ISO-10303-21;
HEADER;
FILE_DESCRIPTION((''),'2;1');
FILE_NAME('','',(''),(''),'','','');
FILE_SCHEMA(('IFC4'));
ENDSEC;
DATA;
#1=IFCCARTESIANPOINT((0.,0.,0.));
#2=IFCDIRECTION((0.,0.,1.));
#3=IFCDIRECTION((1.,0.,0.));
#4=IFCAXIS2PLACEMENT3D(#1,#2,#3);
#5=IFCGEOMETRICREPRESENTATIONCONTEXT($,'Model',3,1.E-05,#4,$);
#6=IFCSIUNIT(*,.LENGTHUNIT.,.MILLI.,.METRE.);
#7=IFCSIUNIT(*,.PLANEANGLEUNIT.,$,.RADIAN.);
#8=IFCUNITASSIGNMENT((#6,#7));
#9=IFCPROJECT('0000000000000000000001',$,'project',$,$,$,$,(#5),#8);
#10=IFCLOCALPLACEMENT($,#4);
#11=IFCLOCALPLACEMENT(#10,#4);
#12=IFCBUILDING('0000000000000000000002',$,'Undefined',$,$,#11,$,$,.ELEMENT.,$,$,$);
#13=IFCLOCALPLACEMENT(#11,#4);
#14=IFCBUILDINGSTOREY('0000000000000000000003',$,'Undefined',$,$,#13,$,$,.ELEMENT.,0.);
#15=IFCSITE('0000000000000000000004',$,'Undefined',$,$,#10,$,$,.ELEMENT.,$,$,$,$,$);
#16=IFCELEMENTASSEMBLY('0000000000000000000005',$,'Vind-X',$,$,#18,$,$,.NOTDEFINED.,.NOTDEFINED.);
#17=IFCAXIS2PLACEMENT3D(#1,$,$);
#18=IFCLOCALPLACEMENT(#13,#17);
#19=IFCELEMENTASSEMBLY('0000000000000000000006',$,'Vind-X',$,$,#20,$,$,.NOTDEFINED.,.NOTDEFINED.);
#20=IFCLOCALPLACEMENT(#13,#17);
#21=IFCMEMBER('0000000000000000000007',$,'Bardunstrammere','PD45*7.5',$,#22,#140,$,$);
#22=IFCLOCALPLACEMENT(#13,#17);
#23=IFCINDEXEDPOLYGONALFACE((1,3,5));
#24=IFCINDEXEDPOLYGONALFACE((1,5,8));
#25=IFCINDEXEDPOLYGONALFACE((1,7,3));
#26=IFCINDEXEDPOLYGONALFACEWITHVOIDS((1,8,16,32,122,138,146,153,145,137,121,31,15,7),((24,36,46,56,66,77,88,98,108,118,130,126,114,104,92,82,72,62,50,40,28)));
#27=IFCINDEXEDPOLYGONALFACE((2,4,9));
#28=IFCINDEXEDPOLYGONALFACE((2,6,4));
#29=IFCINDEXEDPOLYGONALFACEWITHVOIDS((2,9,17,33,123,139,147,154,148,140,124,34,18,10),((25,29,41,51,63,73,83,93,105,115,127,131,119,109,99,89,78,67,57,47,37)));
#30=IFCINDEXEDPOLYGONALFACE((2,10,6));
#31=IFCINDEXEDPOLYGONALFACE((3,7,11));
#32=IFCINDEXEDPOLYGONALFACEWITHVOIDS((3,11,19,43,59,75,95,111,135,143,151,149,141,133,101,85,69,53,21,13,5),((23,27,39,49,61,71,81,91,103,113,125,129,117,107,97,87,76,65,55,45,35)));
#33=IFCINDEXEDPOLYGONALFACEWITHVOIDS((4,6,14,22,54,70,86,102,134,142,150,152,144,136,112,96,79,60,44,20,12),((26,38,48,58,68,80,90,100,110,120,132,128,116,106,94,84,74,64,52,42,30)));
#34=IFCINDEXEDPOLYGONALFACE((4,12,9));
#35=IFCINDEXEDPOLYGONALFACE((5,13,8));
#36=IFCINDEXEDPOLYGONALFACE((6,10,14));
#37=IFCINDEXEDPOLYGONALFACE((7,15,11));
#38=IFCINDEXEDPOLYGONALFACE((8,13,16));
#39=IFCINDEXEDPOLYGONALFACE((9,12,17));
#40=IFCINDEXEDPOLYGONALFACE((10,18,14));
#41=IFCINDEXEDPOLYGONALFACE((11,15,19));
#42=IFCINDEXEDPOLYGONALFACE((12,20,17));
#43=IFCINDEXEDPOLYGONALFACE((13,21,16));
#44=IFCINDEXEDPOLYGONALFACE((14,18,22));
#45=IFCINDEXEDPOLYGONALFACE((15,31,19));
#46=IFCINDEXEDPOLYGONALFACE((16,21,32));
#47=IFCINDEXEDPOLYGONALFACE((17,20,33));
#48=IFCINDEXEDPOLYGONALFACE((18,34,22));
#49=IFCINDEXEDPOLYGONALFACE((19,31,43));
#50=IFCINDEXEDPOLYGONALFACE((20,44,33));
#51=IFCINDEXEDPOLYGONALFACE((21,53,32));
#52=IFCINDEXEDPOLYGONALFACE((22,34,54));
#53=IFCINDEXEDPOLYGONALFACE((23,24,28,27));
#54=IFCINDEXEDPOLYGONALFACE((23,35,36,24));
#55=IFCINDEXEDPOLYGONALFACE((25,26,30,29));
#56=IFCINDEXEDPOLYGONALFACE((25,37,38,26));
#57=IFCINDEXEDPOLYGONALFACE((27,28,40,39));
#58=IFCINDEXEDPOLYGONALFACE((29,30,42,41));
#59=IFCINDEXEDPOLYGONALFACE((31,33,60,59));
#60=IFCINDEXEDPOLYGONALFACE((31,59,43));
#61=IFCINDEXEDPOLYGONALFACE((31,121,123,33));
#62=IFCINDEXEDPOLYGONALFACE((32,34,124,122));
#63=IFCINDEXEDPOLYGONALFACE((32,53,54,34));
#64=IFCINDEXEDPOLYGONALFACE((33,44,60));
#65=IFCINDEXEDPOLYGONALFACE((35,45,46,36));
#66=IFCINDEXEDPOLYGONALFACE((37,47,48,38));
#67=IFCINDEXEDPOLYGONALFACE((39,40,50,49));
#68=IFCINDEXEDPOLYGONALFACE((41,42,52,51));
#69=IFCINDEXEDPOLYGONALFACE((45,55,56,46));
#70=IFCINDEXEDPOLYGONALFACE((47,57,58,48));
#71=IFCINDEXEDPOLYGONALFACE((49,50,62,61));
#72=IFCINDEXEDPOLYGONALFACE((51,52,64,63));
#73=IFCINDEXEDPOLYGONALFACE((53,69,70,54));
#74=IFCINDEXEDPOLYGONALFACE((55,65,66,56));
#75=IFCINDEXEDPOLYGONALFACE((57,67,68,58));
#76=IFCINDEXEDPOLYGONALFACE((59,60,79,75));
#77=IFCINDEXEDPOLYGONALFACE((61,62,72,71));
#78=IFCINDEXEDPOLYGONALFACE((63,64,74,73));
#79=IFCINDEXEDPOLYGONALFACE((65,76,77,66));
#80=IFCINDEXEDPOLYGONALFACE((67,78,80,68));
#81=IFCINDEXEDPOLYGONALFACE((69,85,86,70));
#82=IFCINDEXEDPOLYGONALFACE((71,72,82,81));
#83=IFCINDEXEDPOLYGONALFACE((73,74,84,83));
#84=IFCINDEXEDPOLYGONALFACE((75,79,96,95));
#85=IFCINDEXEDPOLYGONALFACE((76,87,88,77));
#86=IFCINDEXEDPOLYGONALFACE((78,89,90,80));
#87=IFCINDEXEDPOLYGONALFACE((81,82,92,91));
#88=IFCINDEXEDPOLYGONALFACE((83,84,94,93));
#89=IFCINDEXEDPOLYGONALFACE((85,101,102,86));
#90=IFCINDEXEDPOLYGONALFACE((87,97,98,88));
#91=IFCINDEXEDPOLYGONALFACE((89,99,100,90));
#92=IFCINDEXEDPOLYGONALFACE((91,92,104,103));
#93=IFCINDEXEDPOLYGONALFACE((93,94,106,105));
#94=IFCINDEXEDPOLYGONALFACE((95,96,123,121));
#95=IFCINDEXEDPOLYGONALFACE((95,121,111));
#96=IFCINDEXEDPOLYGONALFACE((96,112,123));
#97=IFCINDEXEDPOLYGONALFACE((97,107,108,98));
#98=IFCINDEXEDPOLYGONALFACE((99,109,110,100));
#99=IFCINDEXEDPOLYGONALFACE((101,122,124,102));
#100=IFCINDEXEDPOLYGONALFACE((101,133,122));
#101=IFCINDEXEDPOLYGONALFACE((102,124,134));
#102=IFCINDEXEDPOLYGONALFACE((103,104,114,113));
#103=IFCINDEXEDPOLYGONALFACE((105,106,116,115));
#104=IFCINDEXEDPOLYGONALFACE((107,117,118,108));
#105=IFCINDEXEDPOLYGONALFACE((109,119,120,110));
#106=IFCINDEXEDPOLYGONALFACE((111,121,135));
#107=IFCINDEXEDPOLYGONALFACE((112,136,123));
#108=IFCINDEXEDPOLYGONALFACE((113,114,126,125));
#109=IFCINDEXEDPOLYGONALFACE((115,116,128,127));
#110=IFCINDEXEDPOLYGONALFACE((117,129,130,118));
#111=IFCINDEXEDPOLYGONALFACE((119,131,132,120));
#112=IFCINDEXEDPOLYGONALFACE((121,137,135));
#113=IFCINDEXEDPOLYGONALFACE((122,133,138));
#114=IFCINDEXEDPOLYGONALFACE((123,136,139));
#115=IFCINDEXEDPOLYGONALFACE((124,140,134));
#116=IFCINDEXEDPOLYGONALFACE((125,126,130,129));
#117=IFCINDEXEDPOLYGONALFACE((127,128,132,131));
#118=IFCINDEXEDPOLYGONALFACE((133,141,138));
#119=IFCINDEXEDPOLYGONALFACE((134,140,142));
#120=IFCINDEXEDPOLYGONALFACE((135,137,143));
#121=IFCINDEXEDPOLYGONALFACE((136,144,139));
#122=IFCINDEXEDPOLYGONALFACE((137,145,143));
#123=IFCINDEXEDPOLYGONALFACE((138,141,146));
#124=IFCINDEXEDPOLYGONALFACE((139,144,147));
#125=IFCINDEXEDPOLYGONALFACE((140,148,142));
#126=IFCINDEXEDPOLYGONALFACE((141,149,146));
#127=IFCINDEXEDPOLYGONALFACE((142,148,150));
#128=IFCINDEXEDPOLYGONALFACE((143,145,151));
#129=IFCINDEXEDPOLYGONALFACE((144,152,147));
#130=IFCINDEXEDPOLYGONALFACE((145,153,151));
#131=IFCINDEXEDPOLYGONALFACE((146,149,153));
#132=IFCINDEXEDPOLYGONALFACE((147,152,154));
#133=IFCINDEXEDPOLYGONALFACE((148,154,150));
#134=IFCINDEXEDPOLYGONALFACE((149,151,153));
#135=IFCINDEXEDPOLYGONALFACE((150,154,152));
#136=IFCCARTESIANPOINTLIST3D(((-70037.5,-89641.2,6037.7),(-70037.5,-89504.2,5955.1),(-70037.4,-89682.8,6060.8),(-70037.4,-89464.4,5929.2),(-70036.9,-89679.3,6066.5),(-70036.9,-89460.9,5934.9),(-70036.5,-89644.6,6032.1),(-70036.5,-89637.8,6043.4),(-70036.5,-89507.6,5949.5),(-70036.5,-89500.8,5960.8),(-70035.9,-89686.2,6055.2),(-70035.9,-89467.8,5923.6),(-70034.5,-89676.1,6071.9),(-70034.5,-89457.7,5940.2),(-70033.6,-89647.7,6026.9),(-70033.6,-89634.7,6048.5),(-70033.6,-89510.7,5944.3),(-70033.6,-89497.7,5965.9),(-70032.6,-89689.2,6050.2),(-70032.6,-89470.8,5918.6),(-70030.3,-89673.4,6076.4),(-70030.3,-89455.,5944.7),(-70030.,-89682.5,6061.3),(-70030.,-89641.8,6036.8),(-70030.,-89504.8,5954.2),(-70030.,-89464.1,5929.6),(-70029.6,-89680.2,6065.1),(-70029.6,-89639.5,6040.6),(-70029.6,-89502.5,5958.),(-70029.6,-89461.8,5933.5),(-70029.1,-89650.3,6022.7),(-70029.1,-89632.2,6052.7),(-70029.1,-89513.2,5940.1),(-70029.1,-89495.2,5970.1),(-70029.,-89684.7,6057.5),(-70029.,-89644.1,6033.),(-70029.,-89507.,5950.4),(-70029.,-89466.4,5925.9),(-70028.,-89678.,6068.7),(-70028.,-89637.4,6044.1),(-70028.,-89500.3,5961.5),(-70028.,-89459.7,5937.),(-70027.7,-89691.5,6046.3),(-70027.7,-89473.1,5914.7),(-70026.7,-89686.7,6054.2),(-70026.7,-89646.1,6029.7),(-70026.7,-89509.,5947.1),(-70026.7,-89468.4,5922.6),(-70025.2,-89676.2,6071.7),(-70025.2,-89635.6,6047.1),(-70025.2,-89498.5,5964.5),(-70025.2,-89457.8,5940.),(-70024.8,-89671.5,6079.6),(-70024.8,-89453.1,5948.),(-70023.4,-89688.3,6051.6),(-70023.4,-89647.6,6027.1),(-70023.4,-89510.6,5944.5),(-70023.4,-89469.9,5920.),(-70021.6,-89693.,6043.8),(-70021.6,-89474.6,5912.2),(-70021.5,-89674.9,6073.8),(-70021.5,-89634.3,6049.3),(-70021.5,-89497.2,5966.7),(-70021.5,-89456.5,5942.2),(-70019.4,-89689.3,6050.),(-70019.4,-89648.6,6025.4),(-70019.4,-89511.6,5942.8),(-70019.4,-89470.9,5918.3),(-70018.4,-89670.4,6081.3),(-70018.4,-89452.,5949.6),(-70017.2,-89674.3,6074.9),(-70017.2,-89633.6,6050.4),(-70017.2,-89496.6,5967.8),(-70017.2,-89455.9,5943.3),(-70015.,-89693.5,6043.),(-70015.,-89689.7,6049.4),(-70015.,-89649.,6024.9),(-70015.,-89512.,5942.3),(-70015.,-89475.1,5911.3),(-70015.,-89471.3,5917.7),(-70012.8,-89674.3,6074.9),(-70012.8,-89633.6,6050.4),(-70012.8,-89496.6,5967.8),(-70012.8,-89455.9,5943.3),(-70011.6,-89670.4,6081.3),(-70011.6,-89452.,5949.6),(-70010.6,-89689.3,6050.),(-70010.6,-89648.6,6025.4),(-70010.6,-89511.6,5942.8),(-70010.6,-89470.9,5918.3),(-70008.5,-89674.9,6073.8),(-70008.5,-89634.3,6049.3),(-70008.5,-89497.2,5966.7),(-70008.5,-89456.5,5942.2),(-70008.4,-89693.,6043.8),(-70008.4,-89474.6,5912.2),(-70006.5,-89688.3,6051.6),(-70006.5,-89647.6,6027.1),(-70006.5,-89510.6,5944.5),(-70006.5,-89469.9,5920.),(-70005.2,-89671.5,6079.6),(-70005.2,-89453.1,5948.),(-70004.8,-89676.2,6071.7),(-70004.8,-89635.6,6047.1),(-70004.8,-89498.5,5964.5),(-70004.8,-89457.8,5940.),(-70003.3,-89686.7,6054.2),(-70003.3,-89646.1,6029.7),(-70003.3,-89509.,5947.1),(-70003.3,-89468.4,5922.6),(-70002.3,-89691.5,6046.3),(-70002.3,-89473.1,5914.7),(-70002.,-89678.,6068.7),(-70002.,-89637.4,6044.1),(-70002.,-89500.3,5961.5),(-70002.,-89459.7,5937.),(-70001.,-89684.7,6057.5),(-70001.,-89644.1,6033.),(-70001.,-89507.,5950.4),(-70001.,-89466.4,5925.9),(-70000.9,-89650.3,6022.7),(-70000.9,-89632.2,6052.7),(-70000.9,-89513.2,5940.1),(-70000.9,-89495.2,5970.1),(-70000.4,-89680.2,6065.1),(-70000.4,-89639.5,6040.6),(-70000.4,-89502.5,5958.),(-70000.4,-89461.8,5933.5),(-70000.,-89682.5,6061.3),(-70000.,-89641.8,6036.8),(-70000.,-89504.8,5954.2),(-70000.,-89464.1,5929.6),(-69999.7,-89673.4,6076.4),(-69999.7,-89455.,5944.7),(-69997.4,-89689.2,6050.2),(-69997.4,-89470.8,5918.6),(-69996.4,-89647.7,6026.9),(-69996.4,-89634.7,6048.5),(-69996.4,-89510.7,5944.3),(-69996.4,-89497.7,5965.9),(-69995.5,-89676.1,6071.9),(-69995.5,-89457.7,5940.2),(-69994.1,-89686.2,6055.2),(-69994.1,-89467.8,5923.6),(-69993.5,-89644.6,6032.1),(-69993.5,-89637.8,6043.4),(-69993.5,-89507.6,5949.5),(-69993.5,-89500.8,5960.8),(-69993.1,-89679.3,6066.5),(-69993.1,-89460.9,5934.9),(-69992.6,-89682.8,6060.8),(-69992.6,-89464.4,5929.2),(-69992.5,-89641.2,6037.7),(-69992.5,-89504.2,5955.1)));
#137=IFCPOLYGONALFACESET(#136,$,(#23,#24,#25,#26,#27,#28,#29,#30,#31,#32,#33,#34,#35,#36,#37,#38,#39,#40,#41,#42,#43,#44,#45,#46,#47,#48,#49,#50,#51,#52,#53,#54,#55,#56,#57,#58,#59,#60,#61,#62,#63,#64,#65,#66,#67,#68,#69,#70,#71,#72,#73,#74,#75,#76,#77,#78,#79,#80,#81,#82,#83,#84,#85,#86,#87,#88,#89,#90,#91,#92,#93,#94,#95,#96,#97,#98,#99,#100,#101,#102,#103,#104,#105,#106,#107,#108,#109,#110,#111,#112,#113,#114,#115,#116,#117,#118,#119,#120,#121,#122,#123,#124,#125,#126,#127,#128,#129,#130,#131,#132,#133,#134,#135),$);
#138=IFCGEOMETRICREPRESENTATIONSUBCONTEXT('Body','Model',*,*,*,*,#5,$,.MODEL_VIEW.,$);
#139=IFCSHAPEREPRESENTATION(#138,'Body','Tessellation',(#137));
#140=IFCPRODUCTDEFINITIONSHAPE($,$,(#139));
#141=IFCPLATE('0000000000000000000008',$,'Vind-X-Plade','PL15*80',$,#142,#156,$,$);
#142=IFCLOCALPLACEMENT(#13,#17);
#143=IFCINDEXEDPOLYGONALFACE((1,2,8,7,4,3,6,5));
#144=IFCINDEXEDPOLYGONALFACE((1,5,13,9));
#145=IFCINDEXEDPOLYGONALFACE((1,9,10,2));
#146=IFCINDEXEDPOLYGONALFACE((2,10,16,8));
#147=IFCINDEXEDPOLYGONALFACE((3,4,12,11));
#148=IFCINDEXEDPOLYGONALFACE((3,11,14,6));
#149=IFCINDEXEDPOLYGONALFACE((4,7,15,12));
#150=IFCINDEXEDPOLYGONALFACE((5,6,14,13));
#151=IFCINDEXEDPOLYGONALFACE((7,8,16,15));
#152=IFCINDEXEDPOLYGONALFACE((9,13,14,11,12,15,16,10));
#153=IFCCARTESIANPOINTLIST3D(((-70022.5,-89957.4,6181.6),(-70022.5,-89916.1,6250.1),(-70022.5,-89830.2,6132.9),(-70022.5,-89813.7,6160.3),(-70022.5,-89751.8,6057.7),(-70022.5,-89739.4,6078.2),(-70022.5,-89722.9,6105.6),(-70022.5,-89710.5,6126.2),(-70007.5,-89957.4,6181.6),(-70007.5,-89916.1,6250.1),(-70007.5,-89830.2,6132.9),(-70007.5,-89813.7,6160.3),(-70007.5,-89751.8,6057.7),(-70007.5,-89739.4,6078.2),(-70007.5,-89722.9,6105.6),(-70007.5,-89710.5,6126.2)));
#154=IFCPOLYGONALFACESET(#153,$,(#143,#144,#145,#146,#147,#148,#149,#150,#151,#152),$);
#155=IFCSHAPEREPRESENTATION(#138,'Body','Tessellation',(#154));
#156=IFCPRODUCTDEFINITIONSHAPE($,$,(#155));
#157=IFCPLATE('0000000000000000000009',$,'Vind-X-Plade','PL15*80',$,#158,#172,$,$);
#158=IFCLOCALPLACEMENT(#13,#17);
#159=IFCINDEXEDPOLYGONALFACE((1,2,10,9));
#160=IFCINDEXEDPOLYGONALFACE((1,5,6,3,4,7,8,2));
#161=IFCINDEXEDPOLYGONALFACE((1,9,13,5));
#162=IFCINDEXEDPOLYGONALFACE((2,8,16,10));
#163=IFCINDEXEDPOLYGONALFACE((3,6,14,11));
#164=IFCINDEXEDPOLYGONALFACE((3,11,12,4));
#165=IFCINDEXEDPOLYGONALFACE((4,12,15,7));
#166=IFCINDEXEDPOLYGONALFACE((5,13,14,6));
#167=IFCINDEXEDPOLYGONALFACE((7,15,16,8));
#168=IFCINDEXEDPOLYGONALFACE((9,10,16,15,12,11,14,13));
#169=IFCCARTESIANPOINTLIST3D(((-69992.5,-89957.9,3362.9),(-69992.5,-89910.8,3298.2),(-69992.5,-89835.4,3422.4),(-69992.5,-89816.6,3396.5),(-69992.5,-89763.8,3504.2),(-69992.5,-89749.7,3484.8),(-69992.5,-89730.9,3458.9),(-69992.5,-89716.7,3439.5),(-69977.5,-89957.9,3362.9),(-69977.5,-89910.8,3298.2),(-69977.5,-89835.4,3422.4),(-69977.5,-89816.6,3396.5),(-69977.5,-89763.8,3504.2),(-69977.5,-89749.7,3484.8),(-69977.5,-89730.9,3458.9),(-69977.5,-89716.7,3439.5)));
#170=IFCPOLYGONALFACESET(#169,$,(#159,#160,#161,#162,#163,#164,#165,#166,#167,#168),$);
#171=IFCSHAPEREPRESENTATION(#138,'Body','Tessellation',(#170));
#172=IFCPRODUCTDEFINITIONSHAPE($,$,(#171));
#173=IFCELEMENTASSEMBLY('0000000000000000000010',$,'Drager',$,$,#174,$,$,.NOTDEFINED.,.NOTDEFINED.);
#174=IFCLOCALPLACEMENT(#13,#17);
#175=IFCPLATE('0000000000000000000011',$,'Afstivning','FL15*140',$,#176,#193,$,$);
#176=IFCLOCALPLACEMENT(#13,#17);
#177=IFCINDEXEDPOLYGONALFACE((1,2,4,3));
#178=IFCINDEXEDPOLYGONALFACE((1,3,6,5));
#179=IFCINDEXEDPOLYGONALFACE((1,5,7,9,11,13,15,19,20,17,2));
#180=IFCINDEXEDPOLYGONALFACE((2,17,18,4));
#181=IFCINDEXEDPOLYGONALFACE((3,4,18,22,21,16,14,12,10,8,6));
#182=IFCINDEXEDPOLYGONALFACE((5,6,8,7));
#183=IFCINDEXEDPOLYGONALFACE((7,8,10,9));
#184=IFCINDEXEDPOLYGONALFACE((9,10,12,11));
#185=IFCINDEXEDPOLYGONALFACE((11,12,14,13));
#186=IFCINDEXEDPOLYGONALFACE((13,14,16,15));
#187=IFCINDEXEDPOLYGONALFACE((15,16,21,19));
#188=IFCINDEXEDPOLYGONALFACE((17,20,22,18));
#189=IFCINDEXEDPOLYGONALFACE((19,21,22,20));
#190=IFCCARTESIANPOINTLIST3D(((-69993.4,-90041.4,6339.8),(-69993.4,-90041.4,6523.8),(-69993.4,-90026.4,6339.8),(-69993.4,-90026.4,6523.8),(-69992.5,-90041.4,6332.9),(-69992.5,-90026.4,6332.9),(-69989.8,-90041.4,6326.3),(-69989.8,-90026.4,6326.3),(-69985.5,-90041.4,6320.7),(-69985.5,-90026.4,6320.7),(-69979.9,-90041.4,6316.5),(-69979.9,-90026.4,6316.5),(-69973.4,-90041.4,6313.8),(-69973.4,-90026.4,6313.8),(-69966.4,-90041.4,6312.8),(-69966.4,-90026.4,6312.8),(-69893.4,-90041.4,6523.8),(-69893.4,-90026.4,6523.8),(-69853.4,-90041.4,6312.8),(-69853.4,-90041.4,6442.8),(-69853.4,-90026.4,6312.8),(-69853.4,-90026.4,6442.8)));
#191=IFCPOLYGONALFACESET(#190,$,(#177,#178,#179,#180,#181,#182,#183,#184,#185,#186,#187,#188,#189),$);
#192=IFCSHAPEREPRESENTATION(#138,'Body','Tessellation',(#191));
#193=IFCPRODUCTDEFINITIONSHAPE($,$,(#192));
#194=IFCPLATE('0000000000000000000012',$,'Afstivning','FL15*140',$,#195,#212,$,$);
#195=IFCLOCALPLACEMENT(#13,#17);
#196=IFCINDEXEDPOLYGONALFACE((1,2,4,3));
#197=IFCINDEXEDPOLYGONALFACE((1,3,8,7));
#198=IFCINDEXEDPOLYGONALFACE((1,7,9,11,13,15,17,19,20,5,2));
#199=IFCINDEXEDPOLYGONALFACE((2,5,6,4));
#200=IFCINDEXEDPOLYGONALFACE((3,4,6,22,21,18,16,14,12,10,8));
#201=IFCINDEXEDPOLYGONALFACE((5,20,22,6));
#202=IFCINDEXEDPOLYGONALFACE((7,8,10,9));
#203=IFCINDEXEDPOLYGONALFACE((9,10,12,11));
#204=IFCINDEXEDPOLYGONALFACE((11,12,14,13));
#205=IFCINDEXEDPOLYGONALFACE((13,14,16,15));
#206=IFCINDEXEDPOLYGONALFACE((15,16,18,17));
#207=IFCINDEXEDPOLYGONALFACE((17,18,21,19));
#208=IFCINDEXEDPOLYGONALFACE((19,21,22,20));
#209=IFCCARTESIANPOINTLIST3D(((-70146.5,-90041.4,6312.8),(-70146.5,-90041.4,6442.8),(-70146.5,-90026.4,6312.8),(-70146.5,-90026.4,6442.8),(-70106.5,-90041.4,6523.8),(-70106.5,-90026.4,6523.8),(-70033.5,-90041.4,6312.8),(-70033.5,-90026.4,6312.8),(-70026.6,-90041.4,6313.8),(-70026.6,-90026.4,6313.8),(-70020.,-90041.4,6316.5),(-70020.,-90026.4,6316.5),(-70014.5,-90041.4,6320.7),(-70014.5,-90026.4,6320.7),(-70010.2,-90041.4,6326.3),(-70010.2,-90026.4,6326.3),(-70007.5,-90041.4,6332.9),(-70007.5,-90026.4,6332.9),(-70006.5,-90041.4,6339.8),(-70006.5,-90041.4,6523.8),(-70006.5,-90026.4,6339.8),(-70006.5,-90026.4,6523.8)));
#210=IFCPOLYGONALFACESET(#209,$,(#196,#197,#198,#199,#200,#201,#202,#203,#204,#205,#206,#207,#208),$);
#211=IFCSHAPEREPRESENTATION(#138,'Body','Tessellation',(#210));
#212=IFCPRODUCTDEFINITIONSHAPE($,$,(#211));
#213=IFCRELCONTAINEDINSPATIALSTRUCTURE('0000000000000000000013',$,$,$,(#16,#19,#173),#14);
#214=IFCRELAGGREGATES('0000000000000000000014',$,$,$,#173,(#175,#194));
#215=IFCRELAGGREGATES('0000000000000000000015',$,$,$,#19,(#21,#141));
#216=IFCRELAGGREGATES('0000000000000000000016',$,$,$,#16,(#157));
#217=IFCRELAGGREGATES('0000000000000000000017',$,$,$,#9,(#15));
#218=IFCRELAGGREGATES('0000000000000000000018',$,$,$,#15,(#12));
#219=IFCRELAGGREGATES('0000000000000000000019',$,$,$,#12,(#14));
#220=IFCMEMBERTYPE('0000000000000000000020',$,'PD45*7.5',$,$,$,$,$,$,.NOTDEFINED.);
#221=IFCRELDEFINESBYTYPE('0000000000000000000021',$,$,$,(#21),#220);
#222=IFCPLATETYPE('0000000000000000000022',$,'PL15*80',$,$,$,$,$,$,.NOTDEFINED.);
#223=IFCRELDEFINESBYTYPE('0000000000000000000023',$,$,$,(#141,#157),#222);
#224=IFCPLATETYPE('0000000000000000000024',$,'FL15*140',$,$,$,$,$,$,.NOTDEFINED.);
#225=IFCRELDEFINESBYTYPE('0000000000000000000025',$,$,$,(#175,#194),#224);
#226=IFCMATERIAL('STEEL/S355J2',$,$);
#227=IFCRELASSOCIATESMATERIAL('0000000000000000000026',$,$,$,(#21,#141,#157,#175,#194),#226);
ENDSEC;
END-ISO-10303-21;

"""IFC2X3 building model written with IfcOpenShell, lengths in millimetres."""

from ifc_helpers import new_model, si_unit, frame, frame_2d, origin_with_axes, origin_2d_with_axis, place, context, subcontext, project, spatial, polyline, circle_curve, parameter, trimmed, segment, composite_curve, rectangle, hollow_circle, outline, extrude, boolean, material, type_object, element, aggregate, save


model = new_model("IFC2X3")

# Units and contexts
model_context = context("Model", 3, precision=1e-05, world=origin_with_axes())
body_context = subcontext(model_context, "Body", "Model", "MODEL_VIEW")
ifc_project = project(units=[si_unit("LENGTHUNIT", "METRE", prefix="MILLI"), si_unit("PLANEANGLEUNIT", "RADIAN")], contexts=[model_context])

# Site, building, storey
site_placement = place(None, origin_with_axes())
site = spatial("IfcSite", under=ifc_project, at=site_placement, Name="Undefined", CompositionType="ELEMENT")
building_placement = place(site_placement, origin_with_axes())
building = spatial("IfcBuilding", under=site, at=building_placement, Name="Undefined", CompositionType="ELEMENT")
storey_placement = place(building_placement, origin_with_axes())
storey = spatial("IfcBuildingStorey", under=building, at=storey_placement, Name="Undefined", CompositionType="ELEMENT", Elevation=0.0)

# Element assembly
assembly_1_placement = place(storey_placement, origin_with_axes())
assembly_1 = element("IfcElementAssembly", 1, at=assembly_1_placement, inside=storey, Name="Vind-X", AssemblyPlace="NOTDEFINED", PredefinedType="NOTDEFINED")
ifc_material_1 = material(Name="STEEL/S355J2")

# Element assembly, member, plate
assembly_2_placement = place(storey_placement, origin_with_axes())
assembly_2 = element("IfcElementAssembly", 2, at=assembly_2_placement, inside=storey, Name="Vind-X", AssemblyPlace="NOTDEFINED", PredefinedType="NOTDEFINED")
member_type_1 = type_object("IfcMemberType", Name="PD45*7.5", PredefinedType="NOTDEFINED")
member_1_placement = place(assembly_2_placement, frame((-70015.0, -89681.9, 6062.2), z_axis=(1.0, 0.0, 0.0), x_axis=(0.0, 0.85644, -0.516247)))
member_1 = element("IfcMember", 3, at=member_1_placement, type_object=member_type_1, material=ifc_material_1, Name="Bardunstrammere", Description="PD45*7.5", context=body_context, shape_type="CSG", body=[
    boolean("DIFFERENCE", extrude(hollow_circle(Radius=22.5, WallThickness=7.5, at=origin_2d_with_axis()), frame((255.0, 0.0, 0.0), z_axis=(-1.0, 0.0, 0.0), x_axis=(0.0, -1.0, 0.0)), (0.0, 0.0, 1.0), 255.0), extrude(rectangle(XDim=35.0, YDim=90.0, at=origin_2d_with_axis()), frame((207.5, 0.0, 0.0), z_axis=(-1.0, 0.0, 0.0), x_axis=(0.0, -1.0, 0.0)), (0.0, 0.0, 1.0), 160.0)),
])
plate_type_1 = type_object("IfcPlateType", Name="PL15*80", PredefinedType="NOTDEFINED")
plate_1_placement = place(assembly_2_placement, frame((-70015.0, -89957.4, 6181.6), z_axis=(-1.0, 0.0, 0.0), x_axis=(0.0, 0.516238, 0.856445)))
plate_1 = element("IfcPlate", 4, at=plate_1_placement, type_object=plate_type_1, material=ifc_material_1, Name="Vind-X-Plade", Description="PL15*80", context=body_context, shape_type="CSG", body=[
    boolean("DIFFERENCE", extrude(outline(polyline([(0.0, 0.0), (80.0, 0.0), (80.0, 240.0), (0.0, 240.0), (0.0, 0.0)])), frame((0.0, 0.0, -7.5), z_axis=(0.0, 0.0, 1.0), x_axis=(1.0, 0.0, 0.0)), (0.0, 0.0, 1.0), 15.0), extrude(outline(polyline([(0.0, 0.0), (106.0, 0.0), (106.0, 32.0), (0.0, 32.0), (0.0, 0.0)])), frame((56.0, 240.0, 8.5), z_axis=(0.0, 0.0, -1.0), x_axis=(0.000011, -1.0, 0.0)), (0.0, 0.0, 1.0), 17.0)),
])

# Plate
plate_2_placement = place(assembly_1_placement, frame((-69985.0, -89910.8, 3298.2), z_axis=(-1.0, 0.0, 0.0), x_axis=(0.0, -0.588607, 0.80842)))
plate_2 = element("IfcPlate", 5, at=plate_2_placement, type_object=plate_type_1, material=ifc_material_1, Name="Vind-X-Plade", Description="PL15*80", context=body_context, shape_type="CSG", body=[
    boolean("DIFFERENCE", extrude(outline(polyline([(0.0, 0.0), (80.0, 0.0), (80.0, 240.0), (0.0, 240.0), (0.0, 0.0)])), frame((0.0, 0.0, -7.5), z_axis=(0.0, 0.0, 1.0), x_axis=(1.0, 0.0, 0.0)), (0.0, 0.0, 1.0), 15.0), extrude(outline(polyline([(0.0, 0.0), (106.0, 0.0), (106.0, 32.0), (0.0, 32.0), (0.0, 0.0)])), frame((56.0, 240.0, 8.5), z_axis=(0.0, 0.0, -1.0), x_axis=(-0.00001, -1.0, 0.0)), (0.0, 0.0, 1.0), 17.0)),
])

# Element assembly, plates
assembly_3_placement = place(storey_placement, origin_with_axes())
assembly_3 = element("IfcElementAssembly", 6, at=assembly_3_placement, inside=storey, Name="Drager", AssemblyPlace="NOTDEFINED", PredefinedType="NOTDEFINED")
plate_type_2 = type_object("IfcPlateType", Name="FL15*140", PredefinedType="NOTDEFINED")
plate_3_placement = place(assembly_3_placement, frame((-69993.4, -90033.9, 6312.8), z_axis=(0.0, -1.0, 0.0), x_axis=(1.0, 0.0, 0.0)))
plate_3 = element("IfcPlate", 7, at=plate_3_placement, type_object=plate_type_2, material=ifc_material_1, Name="Afstivning", Description="FL15*140", context=body_context, shape_type="SweptSolid", body=[
    extrude(outline(composite_curve([segment(trimmed(circle_curve(frame_2d((27.0, 27.0), x_axis=(-1.0, 0.0)), 27.0), [parameter(0.0)], [parameter(1.570796)], True, "PARAMETER"), True, "CONTINUOUS"), segment(polyline([(27.0, 0.0), (140.0, 0.0), (140.0, 130.0), (100.0, 211.0), (0.0, 211.0), (0.0, 27.0)]), True, "CONTINUOUS")], self_intersect=True)), frame((0.0, 0.0, -7.5), z_axis=(0.0, 0.0, 1.0), x_axis=(1.0, 0.0, 0.0)), (0.0, 0.0, 1.0), 15.0),
])
plate_4_placement = place(assembly_3_placement, frame((-70146.5, -90033.9, 6312.8), z_axis=(0.0, -1.0, 0.0), x_axis=(1.0, 0.0, 0.0)))
plate_4 = element("IfcPlate", 8, at=plate_4_placement, type_object=plate_type_2, material=ifc_material_1, Name="Afstivning", Description="FL15*140", context=body_context, shape_type="SweptSolid", body=[
    extrude(outline(composite_curve([segment(polyline([(0.0, 0.0), (113.0, 0.0)]), True, "CONTINUOUS"), segment(trimmed(circle_curve(frame_2d((113.0, 27.0), x_axis=(0.0, -1.0)), 27.0), [parameter(0.0)], [parameter(1.570796)], True, "PARAMETER"), True, "CONTINUOUS"), segment(polyline([(140.0, 27.0), (140.0, 211.0), (40.0, 211.0), (0.0, 130.0), (0.0, 0.0)]), True, "CONTINUOUS")], self_intersect=True)), frame((0.0, 0.0, -7.5), z_axis=(0.0, 0.0, 1.0), x_axis=(1.0, 0.0, 0.0)), (0.0, 0.0, 1.0), 15.0),
])

aggregate(assembly_3, [plate_3, plate_4])

aggregate(assembly_2, [member_1, plate_1])
aggregate(assembly_1, [plate_2])

save(model, "model.ifc")
